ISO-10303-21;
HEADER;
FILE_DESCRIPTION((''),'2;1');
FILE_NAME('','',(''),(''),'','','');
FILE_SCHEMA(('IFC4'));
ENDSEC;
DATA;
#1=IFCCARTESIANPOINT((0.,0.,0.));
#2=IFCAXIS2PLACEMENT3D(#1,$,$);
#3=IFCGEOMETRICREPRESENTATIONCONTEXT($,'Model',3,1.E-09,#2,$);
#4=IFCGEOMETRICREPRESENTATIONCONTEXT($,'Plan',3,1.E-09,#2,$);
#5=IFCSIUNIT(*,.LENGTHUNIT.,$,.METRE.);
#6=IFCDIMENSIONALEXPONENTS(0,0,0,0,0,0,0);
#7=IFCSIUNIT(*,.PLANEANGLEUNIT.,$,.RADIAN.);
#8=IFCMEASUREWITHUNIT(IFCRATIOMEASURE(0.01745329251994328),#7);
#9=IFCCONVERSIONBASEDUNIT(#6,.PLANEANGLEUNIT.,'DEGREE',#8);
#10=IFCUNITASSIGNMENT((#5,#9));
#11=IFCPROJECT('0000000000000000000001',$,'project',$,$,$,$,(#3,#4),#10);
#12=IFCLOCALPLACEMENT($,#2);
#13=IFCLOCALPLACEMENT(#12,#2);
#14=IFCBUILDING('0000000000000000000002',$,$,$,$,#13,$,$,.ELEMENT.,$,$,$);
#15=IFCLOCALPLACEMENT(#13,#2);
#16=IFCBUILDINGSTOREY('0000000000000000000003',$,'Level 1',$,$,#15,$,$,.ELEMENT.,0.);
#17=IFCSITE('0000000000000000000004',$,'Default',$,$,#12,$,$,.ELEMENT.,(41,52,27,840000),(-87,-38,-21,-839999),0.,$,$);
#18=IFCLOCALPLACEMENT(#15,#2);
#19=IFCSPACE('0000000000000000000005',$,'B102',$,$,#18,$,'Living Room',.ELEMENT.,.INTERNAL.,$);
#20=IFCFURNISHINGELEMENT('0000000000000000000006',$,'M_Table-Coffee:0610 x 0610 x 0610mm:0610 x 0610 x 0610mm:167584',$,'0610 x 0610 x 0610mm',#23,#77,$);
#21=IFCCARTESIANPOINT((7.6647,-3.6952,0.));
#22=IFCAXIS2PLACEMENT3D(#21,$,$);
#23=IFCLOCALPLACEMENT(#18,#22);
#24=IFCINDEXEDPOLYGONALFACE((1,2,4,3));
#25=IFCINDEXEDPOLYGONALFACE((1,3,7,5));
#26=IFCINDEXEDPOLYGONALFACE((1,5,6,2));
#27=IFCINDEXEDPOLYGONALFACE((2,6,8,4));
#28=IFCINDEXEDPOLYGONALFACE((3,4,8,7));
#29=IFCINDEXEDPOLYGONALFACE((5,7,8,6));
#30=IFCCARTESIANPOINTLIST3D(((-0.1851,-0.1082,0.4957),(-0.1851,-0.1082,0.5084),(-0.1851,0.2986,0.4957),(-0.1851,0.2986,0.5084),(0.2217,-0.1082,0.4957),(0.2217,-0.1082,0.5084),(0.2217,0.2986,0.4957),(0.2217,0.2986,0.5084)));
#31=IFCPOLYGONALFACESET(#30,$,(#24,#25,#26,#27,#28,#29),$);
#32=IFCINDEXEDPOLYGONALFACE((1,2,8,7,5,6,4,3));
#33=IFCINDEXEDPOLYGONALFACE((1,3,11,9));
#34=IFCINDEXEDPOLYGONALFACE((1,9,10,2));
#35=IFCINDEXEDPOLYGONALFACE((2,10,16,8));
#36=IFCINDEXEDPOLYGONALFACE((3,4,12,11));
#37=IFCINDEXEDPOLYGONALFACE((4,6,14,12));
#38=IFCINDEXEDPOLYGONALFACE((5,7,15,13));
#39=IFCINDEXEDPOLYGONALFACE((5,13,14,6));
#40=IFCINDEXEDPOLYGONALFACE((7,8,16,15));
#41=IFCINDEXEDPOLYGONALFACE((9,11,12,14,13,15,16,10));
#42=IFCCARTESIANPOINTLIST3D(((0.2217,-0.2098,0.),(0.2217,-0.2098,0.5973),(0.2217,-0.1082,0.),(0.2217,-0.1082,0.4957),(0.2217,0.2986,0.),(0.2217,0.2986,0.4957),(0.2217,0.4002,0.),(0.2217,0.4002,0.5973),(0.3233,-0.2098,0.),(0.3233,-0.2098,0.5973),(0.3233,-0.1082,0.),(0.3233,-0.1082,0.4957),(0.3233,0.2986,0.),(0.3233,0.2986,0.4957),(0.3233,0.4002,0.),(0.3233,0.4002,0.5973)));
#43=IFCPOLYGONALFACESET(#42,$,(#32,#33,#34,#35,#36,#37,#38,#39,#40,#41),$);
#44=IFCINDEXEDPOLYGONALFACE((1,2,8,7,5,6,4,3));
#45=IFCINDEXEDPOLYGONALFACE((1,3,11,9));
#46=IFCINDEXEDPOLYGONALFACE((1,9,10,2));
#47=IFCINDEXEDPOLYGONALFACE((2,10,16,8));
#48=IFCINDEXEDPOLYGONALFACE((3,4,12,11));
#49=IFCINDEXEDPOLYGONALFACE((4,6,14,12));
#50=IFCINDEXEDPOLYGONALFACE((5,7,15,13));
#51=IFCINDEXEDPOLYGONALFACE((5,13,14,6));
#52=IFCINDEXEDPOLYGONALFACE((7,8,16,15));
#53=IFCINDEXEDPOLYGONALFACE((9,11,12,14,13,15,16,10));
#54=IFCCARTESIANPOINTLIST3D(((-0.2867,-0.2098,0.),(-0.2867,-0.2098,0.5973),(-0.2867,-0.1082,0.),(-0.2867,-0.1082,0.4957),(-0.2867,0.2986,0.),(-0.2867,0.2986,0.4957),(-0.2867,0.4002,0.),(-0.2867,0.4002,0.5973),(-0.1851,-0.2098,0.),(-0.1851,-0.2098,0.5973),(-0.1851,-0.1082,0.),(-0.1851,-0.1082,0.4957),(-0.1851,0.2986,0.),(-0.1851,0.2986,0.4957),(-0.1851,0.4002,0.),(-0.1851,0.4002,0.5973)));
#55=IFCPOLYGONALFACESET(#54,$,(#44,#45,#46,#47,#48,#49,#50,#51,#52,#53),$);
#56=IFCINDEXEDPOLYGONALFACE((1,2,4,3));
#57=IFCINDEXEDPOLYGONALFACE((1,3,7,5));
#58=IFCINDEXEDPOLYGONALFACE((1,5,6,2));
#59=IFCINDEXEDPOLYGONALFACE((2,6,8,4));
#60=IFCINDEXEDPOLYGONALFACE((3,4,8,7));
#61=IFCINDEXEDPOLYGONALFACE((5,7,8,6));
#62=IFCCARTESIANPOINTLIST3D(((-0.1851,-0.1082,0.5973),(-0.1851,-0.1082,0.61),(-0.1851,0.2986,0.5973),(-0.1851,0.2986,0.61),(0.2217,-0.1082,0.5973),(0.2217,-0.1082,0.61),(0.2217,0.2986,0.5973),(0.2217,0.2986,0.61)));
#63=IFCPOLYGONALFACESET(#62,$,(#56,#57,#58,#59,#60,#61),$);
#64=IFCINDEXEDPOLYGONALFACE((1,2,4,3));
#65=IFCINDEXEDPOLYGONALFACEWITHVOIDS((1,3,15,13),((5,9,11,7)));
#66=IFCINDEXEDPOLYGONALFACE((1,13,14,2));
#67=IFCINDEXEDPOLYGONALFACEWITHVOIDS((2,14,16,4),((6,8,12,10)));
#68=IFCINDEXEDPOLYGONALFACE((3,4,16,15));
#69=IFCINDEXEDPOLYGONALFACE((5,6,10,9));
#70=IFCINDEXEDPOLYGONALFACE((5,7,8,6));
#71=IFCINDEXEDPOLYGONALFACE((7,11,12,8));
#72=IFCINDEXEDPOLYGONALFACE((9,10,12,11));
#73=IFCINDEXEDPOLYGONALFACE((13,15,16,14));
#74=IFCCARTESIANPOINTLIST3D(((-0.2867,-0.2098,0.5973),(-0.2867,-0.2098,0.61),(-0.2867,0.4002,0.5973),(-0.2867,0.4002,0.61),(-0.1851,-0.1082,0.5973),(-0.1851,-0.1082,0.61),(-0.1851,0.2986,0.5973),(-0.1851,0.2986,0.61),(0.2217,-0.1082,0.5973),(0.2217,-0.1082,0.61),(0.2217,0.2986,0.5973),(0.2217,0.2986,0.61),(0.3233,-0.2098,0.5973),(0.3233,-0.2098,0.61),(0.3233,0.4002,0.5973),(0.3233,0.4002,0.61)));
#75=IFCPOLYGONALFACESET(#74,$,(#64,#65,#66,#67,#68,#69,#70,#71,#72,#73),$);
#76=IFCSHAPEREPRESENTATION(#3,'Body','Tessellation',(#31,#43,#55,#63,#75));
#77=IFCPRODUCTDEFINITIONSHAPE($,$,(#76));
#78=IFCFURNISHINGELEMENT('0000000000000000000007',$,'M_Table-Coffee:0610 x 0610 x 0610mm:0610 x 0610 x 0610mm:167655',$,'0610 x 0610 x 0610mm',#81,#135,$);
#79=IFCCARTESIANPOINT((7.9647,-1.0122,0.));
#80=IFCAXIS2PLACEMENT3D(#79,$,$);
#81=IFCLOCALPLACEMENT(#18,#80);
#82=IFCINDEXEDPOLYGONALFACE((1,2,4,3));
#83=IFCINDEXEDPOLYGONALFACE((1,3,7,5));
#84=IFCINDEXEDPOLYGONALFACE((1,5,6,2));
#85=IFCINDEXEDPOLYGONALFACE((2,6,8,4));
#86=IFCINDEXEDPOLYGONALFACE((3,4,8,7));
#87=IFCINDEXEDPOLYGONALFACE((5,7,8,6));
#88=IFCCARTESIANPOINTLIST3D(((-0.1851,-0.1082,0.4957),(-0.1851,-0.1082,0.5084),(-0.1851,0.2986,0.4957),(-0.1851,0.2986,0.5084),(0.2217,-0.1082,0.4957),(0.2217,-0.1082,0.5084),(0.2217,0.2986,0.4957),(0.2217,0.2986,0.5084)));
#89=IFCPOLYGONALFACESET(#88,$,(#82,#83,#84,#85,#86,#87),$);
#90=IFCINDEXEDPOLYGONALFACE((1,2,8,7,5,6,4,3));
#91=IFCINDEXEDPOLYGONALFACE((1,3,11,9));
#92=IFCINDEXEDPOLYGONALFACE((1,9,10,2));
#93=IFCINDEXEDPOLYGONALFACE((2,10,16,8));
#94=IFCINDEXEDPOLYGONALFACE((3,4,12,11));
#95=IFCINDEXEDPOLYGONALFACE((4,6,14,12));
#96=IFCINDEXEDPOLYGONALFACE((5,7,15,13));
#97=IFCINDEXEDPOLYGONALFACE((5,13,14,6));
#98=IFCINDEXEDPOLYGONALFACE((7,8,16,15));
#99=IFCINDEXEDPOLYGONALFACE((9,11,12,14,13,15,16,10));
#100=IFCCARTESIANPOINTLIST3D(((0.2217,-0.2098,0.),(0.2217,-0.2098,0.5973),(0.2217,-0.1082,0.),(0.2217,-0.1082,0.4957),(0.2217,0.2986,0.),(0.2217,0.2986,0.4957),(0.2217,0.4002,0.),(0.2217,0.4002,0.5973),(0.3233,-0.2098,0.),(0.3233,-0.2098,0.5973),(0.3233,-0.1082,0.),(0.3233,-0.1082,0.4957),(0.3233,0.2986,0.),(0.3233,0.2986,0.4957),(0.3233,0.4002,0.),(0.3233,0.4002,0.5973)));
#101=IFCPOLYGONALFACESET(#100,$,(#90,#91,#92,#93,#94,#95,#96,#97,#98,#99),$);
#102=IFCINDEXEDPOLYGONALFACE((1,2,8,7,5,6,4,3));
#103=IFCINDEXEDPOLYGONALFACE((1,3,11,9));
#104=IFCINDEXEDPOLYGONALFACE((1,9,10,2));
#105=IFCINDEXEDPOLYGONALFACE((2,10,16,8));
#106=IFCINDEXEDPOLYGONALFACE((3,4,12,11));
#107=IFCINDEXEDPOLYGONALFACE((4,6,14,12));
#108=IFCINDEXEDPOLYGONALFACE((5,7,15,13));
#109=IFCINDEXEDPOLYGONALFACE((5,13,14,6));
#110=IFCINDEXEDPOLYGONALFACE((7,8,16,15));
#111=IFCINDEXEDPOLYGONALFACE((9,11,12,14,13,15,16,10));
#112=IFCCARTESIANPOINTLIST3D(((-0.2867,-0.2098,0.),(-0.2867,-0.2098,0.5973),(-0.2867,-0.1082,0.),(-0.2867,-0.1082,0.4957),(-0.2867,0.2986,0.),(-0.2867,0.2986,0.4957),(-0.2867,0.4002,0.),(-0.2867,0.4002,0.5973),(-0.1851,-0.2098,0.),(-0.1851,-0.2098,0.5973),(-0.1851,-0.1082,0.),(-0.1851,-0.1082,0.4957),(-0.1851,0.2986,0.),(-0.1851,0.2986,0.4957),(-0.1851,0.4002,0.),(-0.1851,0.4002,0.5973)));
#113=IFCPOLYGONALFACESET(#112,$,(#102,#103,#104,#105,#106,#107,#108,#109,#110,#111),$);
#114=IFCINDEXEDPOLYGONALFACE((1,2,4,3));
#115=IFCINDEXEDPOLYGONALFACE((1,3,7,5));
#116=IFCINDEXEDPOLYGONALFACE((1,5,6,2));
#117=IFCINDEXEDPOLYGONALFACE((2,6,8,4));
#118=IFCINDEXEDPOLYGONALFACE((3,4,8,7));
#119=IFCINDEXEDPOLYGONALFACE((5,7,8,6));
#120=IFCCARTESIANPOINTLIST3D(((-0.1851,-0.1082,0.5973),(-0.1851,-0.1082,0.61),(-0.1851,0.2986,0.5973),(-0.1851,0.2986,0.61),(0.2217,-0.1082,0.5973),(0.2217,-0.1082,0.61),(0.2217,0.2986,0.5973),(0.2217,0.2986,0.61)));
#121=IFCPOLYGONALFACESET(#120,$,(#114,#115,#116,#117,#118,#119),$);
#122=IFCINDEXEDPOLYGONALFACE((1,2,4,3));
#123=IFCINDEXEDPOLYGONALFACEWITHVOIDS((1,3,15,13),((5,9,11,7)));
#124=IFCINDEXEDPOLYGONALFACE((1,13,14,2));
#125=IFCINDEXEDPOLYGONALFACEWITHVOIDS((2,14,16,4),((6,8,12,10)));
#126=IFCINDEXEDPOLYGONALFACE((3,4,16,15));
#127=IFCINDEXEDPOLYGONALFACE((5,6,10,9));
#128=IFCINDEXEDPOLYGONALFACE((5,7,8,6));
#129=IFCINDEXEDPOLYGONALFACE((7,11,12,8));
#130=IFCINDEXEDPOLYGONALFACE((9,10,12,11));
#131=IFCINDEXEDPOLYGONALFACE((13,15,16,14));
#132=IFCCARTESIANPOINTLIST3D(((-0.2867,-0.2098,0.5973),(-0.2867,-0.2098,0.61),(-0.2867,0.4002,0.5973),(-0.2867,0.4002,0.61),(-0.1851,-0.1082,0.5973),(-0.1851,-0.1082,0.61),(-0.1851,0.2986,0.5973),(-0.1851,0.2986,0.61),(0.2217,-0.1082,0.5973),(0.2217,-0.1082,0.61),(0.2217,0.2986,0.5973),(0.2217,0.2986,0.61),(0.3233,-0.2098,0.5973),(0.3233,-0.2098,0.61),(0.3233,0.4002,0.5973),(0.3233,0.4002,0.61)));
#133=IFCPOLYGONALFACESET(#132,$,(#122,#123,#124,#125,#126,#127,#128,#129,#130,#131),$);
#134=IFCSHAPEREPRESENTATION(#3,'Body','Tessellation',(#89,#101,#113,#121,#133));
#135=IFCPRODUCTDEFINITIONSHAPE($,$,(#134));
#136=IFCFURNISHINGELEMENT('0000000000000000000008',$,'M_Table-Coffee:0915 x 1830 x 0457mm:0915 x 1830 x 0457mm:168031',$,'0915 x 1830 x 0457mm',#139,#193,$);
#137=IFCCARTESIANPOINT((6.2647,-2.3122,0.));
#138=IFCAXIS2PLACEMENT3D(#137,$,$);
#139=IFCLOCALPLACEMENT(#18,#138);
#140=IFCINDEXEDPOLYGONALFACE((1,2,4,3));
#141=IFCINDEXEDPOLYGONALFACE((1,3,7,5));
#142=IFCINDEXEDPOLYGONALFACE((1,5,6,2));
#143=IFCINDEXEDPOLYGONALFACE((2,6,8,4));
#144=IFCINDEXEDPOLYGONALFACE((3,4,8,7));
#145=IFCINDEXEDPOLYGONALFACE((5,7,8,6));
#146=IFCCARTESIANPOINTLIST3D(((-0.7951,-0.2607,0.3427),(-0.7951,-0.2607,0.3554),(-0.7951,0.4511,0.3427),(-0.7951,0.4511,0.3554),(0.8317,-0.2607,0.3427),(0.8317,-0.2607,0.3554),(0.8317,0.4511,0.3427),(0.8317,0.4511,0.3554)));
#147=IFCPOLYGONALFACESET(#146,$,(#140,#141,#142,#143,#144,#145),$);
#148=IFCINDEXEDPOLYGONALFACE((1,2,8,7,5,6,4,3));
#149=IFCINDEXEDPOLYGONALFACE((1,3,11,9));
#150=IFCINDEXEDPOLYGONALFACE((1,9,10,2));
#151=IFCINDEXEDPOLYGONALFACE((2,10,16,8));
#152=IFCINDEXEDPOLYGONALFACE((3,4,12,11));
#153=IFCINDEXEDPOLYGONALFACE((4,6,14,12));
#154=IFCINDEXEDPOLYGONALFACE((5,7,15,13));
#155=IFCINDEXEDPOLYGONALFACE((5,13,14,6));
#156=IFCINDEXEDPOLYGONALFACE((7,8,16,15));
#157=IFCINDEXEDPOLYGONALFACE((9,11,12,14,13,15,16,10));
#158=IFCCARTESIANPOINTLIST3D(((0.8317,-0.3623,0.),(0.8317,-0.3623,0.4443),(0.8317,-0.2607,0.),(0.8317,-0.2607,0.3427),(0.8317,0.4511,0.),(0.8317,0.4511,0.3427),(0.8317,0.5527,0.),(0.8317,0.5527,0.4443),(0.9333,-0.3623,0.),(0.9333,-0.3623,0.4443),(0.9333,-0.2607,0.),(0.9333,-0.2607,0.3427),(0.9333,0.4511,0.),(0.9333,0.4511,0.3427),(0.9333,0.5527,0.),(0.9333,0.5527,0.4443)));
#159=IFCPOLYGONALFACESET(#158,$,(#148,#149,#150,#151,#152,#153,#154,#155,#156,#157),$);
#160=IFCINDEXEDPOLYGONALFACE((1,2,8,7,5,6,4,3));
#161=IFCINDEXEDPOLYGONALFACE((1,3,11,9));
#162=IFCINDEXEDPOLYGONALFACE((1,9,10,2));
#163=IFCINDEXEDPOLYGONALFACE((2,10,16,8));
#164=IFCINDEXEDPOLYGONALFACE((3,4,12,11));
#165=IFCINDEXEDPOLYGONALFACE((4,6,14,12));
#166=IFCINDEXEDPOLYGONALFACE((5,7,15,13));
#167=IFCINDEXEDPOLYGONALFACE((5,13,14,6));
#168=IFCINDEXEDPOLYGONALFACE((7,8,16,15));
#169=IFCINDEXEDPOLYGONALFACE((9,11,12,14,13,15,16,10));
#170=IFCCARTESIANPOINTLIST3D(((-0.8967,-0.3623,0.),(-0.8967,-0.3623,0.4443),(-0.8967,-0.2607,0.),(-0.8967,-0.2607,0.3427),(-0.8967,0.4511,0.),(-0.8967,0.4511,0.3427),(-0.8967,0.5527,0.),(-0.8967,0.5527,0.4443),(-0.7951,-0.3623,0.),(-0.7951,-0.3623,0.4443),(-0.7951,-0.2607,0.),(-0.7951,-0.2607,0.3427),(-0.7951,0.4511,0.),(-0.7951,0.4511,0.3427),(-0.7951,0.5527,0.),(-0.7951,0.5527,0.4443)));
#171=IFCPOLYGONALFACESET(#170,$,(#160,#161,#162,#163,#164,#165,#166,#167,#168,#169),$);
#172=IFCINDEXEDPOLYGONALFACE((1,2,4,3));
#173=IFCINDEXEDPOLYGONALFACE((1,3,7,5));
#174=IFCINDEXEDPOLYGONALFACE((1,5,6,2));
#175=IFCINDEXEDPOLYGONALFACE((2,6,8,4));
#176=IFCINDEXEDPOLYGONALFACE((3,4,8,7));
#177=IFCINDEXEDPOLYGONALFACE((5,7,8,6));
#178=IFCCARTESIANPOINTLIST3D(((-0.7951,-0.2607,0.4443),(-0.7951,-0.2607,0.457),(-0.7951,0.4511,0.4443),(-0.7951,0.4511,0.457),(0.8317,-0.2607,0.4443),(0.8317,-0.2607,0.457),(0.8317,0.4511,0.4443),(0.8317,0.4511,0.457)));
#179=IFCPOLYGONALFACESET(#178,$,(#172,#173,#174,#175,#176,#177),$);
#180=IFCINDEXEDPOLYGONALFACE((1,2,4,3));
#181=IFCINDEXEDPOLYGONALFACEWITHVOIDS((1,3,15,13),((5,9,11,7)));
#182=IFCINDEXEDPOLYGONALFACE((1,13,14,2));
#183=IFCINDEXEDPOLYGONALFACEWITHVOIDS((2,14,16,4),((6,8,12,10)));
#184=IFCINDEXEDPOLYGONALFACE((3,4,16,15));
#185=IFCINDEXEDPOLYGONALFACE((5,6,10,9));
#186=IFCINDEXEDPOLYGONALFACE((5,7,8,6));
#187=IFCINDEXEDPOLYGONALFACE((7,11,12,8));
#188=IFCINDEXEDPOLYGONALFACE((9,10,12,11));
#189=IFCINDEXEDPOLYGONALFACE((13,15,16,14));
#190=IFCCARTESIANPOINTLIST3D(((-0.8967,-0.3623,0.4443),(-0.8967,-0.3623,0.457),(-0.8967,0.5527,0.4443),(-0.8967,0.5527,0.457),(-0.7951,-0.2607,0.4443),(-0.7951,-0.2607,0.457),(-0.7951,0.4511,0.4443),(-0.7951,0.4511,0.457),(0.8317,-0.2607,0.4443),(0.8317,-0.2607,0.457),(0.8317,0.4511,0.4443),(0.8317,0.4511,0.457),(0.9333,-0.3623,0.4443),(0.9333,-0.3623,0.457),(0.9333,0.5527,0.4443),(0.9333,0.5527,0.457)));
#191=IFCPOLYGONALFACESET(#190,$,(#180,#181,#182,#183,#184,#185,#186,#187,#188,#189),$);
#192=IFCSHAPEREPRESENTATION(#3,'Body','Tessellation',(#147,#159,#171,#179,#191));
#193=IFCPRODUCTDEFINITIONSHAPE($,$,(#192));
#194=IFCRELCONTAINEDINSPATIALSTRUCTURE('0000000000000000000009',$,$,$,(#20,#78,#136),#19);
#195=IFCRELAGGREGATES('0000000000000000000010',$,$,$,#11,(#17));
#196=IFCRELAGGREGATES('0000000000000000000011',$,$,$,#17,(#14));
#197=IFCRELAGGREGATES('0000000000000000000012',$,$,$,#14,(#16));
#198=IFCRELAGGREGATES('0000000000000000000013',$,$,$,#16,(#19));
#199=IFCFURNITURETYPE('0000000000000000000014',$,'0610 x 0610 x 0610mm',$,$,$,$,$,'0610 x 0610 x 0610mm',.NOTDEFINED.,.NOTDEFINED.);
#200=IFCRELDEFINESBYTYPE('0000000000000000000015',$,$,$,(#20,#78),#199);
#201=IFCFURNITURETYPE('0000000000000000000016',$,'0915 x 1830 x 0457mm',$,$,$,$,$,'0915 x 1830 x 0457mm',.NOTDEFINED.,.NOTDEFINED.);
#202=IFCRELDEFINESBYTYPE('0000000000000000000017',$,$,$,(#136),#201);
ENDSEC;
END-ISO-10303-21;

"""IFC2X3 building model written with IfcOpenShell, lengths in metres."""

from ifc_helpers import new_model, entity, si_unit, converted_unit, frame, origin, origin_2d_with_axis, place, context, project, spatial, polyline, rectangle, outline, extrude, source, transform, mapped, type_object, type_shapes, element, save


model = new_model("IFC2X3")

# Units and contexts
model_context = context("Model", 3, precision=1e-09, world=origin())
plan_context = context("Plan", 3, precision=1e-09, world=origin())
ifc_project = project(units=[si_unit("LENGTHUNIT", "METRE"), converted_unit("PLANEANGLEUNIT", "DEGREE", entity("IfcRatioMeasure", 0.01745329251994328), si_unit("PLANEANGLEUNIT", "RADIAN"), dimensions=[0, 0, 0, 0, 0, 0, 0])], contexts=[model_context, plan_context])

# Site, building, storey
site_placement = place(None, origin())
site = spatial("IfcSite", under=ifc_project, at=site_placement, Name="Default", CompositionType="ELEMENT", RefLatitude=(41, 52, 27, 840000), RefLongitude=(-87, -38, -21, -839999), RefElevation=0.0)
building_placement = place(site_placement, origin())
building = spatial("IfcBuilding", under=site, at=building_placement, CompositionType="ELEMENT")
storey_placement = place(building_placement, origin())
storey = spatial("IfcBuildingStorey", under=building, at=storey_placement, Name="Level 1", CompositionType="ELEMENT", Elevation=0.0)

# Shared definitions
space_1_placement = place(storey_placement, origin())
space_1 = spatial("IfcSpace", under=storey, at=space_1_placement, Name="B102", LongName="Living Room", CompositionType="ELEMENT", InteriorOrExteriorSpace="INTERNAL")

# Furnishing elements
furniture_type_1 = type_object("IfcFurnitureType", Name="0610 x 0610 x 0610mm", ElementType="0610 x 0610 x 0610mm", AssemblyPlace="NOTDEFINED")
shared_shape_1 = source(origin(), model_context, "Body", "SweptSolid", [
    extrude(rectangle(XDim=0.4068, YDim=0.4068, at=origin_2d_with_axis()), frame((0.0183, 0.0952, 0.4957), z_axis=(0.0, 0.0, 1.0), x_axis=(-1.0, 0.0, 0.0)), (0.0, 0.0, 1.0), 0.0127),
    extrude(outline(polyline([(-0.2732, -0.305), (0.324, -0.305), (0.324, 0.305), (-0.2732, 0.305), (-0.2732, 0.2034), (0.2225, 0.2034), (0.2225, -0.2034), (-0.2732, -0.2034), (-0.2732, -0.305)])), frame((0.2217, 0.0952, 0.2732), z_axis=(1.0, 0.0, 0.0), x_axis=(0.0, 0.0, 1.0)), (0.0, 0.0, 1.0), 0.1016),
    extrude(outline(polyline([(-0.305, -0.3241), (0.305, -0.3241), (0.305, 0.2733), (0.2034, 0.2733), (0.2034, -0.2224), (-0.2034, -0.2224), (-0.2034, 0.2733), (-0.305, 0.2733), (-0.305, -0.3241)])), frame((-0.2867, 0.0952, 0.2733), z_axis=(1.0, 0.0, 0.0), x_axis=(0.0, -1.0, 0.0)), (0.0, 0.0, 1.0), 0.1016),
    extrude(rectangle(XDim=0.4068, YDim=0.4068, at=origin_2d_with_axis()), frame((0.0183, 0.0952, 0.5973), z_axis=(0.0, 0.0, 1.0), x_axis=(-1.0, 0.0, 0.0)), (0.0, 0.0, 1.0), 0.0127),
    extrude(outline(polyline([(-0.305, -0.305), (0.305, -0.305), (0.305, 0.305), (-0.305, 0.305), (-0.305, -0.305)]), holes=[polyline([(-0.2034, -0.2034), (-0.2034, 0.2034), (0.2034, 0.2034), (0.2034, -0.2034), (-0.2034, -0.2034)])]), frame((0.0183, 0.0952, 0.5973), z_axis=(0.0, 0.0, 1.0), x_axis=(-1.0, 0.0, 0.0)), (0.0, 0.0, 1.0), 0.0127),
])
type_shapes(furniture_type_1, [shared_shape_1])
for number, where, name in (
    (1, (7.6647, -3.6952, 0.0), "M_Table-Coffee:0610 x 0610 x 0610mm:0610 x 0610 x 0610mm:167584"),
    (2, (7.9647, -1.0122, 0.0), "M_Table-Coffee:0610 x 0610 x 0610mm:0610 x 0610 x 0610mm:167655"),
):
    element("IfcFurnishingElement", number, at=place(space_1_placement, frame(where)), inside=space_1, type_object=furniture_type_1, Name=name, ObjectType="0610 x 0610 x 0610mm", context=model_context, shape_type="MappedRepresentation", body=[
        mapped(shared_shape_1, transform((0.0, 0.0, 0.0), scale=1.0)),
    ])
furniture_type_2 = type_object("IfcFurnitureType", Name="0915 x 1830 x 0457mm", ElementType="0915 x 1830 x 0457mm", AssemblyPlace="NOTDEFINED")
shared_shape_2 = source(origin(), model_context, "Body", "SweptSolid", [
    extrude(rectangle(XDim=1.6268, YDim=0.7118, at=origin_2d_with_axis()), frame((0.0183, 0.0952, 0.3427), z_axis=(0.0, 0.0, 1.0), x_axis=(-1.0, 0.0, 0.0)), (0.0, 0.0, 1.0), 0.0127),
    extrude(outline(polyline([(-0.1967, -0.4575), (0.2475, -0.4575), (0.2475, 0.4575), (-0.1967, 0.4575), (-0.1967, 0.3559), (0.146, 0.3559), (0.146, -0.3559), (-0.1967, -0.3559), (-0.1967, -0.4575)])), frame((0.8317, 0.0952, 0.1967), z_axis=(1.0, 0.0, 0.0), x_axis=(0.0, 0.0, 1.0)), (0.0, 0.0, 1.0), 0.1016),
    extrude(outline(polyline([(-0.4575, -0.2476), (0.4575, -0.2476), (0.4575, 0.1968), (0.3559, 0.1968), (0.3559, -0.1459), (-0.3559, -0.1459), (-0.3559, 0.1968), (-0.4575, 0.1968), (-0.4575, -0.2476)])), frame((-0.8967, 0.0952, 0.1968), z_axis=(1.0, 0.0, 0.0), x_axis=(0.0, -1.0, 0.0)), (0.0, 0.0, 1.0), 0.1016),
    extrude(rectangle(XDim=1.6268, YDim=0.7118, at=origin_2d_with_axis()), frame((0.0183, 0.0952, 0.4443), z_axis=(0.0, 0.0, 1.0), x_axis=(-1.0, 0.0, 0.0)), (0.0, 0.0, 1.0), 0.0127),
    extrude(outline(polyline([(-0.915, -0.4575), (0.915, -0.4575), (0.915, 0.4575), (-0.915, 0.4575), (-0.915, -0.4575)]), holes=[polyline([(-0.8134, -0.3559), (-0.8134, 0.3559), (0.8134, 0.3559), (0.8134, -0.3559), (-0.8134, -0.3559)])]), frame((0.0183, 0.0952, 0.4443), z_axis=(0.0, 0.0, 1.0), x_axis=(-1.0, 0.0, 0.0)), (0.0, 0.0, 1.0), 0.0127),
])
type_shapes(furniture_type_2, [shared_shape_2])
furnishing_1_placement = place(space_1_placement, frame((6.2647, -2.3122, 0.0)))
element("IfcFurnishingElement", 3, at=furnishing_1_placement, inside=space_1, type_object=furniture_type_2, Name="M_Table-Coffee:0915 x 1830 x 0457mm:0915 x 1830 x 0457mm:168031", ObjectType="0915 x 1830 x 0457mm", context=model_context, shape_type="MappedRepresentation", body=[
    mapped(shared_shape_2, transform((0.0, 0.0, 0.0), scale=1.0)),
])

save(model, "model.ifc")
